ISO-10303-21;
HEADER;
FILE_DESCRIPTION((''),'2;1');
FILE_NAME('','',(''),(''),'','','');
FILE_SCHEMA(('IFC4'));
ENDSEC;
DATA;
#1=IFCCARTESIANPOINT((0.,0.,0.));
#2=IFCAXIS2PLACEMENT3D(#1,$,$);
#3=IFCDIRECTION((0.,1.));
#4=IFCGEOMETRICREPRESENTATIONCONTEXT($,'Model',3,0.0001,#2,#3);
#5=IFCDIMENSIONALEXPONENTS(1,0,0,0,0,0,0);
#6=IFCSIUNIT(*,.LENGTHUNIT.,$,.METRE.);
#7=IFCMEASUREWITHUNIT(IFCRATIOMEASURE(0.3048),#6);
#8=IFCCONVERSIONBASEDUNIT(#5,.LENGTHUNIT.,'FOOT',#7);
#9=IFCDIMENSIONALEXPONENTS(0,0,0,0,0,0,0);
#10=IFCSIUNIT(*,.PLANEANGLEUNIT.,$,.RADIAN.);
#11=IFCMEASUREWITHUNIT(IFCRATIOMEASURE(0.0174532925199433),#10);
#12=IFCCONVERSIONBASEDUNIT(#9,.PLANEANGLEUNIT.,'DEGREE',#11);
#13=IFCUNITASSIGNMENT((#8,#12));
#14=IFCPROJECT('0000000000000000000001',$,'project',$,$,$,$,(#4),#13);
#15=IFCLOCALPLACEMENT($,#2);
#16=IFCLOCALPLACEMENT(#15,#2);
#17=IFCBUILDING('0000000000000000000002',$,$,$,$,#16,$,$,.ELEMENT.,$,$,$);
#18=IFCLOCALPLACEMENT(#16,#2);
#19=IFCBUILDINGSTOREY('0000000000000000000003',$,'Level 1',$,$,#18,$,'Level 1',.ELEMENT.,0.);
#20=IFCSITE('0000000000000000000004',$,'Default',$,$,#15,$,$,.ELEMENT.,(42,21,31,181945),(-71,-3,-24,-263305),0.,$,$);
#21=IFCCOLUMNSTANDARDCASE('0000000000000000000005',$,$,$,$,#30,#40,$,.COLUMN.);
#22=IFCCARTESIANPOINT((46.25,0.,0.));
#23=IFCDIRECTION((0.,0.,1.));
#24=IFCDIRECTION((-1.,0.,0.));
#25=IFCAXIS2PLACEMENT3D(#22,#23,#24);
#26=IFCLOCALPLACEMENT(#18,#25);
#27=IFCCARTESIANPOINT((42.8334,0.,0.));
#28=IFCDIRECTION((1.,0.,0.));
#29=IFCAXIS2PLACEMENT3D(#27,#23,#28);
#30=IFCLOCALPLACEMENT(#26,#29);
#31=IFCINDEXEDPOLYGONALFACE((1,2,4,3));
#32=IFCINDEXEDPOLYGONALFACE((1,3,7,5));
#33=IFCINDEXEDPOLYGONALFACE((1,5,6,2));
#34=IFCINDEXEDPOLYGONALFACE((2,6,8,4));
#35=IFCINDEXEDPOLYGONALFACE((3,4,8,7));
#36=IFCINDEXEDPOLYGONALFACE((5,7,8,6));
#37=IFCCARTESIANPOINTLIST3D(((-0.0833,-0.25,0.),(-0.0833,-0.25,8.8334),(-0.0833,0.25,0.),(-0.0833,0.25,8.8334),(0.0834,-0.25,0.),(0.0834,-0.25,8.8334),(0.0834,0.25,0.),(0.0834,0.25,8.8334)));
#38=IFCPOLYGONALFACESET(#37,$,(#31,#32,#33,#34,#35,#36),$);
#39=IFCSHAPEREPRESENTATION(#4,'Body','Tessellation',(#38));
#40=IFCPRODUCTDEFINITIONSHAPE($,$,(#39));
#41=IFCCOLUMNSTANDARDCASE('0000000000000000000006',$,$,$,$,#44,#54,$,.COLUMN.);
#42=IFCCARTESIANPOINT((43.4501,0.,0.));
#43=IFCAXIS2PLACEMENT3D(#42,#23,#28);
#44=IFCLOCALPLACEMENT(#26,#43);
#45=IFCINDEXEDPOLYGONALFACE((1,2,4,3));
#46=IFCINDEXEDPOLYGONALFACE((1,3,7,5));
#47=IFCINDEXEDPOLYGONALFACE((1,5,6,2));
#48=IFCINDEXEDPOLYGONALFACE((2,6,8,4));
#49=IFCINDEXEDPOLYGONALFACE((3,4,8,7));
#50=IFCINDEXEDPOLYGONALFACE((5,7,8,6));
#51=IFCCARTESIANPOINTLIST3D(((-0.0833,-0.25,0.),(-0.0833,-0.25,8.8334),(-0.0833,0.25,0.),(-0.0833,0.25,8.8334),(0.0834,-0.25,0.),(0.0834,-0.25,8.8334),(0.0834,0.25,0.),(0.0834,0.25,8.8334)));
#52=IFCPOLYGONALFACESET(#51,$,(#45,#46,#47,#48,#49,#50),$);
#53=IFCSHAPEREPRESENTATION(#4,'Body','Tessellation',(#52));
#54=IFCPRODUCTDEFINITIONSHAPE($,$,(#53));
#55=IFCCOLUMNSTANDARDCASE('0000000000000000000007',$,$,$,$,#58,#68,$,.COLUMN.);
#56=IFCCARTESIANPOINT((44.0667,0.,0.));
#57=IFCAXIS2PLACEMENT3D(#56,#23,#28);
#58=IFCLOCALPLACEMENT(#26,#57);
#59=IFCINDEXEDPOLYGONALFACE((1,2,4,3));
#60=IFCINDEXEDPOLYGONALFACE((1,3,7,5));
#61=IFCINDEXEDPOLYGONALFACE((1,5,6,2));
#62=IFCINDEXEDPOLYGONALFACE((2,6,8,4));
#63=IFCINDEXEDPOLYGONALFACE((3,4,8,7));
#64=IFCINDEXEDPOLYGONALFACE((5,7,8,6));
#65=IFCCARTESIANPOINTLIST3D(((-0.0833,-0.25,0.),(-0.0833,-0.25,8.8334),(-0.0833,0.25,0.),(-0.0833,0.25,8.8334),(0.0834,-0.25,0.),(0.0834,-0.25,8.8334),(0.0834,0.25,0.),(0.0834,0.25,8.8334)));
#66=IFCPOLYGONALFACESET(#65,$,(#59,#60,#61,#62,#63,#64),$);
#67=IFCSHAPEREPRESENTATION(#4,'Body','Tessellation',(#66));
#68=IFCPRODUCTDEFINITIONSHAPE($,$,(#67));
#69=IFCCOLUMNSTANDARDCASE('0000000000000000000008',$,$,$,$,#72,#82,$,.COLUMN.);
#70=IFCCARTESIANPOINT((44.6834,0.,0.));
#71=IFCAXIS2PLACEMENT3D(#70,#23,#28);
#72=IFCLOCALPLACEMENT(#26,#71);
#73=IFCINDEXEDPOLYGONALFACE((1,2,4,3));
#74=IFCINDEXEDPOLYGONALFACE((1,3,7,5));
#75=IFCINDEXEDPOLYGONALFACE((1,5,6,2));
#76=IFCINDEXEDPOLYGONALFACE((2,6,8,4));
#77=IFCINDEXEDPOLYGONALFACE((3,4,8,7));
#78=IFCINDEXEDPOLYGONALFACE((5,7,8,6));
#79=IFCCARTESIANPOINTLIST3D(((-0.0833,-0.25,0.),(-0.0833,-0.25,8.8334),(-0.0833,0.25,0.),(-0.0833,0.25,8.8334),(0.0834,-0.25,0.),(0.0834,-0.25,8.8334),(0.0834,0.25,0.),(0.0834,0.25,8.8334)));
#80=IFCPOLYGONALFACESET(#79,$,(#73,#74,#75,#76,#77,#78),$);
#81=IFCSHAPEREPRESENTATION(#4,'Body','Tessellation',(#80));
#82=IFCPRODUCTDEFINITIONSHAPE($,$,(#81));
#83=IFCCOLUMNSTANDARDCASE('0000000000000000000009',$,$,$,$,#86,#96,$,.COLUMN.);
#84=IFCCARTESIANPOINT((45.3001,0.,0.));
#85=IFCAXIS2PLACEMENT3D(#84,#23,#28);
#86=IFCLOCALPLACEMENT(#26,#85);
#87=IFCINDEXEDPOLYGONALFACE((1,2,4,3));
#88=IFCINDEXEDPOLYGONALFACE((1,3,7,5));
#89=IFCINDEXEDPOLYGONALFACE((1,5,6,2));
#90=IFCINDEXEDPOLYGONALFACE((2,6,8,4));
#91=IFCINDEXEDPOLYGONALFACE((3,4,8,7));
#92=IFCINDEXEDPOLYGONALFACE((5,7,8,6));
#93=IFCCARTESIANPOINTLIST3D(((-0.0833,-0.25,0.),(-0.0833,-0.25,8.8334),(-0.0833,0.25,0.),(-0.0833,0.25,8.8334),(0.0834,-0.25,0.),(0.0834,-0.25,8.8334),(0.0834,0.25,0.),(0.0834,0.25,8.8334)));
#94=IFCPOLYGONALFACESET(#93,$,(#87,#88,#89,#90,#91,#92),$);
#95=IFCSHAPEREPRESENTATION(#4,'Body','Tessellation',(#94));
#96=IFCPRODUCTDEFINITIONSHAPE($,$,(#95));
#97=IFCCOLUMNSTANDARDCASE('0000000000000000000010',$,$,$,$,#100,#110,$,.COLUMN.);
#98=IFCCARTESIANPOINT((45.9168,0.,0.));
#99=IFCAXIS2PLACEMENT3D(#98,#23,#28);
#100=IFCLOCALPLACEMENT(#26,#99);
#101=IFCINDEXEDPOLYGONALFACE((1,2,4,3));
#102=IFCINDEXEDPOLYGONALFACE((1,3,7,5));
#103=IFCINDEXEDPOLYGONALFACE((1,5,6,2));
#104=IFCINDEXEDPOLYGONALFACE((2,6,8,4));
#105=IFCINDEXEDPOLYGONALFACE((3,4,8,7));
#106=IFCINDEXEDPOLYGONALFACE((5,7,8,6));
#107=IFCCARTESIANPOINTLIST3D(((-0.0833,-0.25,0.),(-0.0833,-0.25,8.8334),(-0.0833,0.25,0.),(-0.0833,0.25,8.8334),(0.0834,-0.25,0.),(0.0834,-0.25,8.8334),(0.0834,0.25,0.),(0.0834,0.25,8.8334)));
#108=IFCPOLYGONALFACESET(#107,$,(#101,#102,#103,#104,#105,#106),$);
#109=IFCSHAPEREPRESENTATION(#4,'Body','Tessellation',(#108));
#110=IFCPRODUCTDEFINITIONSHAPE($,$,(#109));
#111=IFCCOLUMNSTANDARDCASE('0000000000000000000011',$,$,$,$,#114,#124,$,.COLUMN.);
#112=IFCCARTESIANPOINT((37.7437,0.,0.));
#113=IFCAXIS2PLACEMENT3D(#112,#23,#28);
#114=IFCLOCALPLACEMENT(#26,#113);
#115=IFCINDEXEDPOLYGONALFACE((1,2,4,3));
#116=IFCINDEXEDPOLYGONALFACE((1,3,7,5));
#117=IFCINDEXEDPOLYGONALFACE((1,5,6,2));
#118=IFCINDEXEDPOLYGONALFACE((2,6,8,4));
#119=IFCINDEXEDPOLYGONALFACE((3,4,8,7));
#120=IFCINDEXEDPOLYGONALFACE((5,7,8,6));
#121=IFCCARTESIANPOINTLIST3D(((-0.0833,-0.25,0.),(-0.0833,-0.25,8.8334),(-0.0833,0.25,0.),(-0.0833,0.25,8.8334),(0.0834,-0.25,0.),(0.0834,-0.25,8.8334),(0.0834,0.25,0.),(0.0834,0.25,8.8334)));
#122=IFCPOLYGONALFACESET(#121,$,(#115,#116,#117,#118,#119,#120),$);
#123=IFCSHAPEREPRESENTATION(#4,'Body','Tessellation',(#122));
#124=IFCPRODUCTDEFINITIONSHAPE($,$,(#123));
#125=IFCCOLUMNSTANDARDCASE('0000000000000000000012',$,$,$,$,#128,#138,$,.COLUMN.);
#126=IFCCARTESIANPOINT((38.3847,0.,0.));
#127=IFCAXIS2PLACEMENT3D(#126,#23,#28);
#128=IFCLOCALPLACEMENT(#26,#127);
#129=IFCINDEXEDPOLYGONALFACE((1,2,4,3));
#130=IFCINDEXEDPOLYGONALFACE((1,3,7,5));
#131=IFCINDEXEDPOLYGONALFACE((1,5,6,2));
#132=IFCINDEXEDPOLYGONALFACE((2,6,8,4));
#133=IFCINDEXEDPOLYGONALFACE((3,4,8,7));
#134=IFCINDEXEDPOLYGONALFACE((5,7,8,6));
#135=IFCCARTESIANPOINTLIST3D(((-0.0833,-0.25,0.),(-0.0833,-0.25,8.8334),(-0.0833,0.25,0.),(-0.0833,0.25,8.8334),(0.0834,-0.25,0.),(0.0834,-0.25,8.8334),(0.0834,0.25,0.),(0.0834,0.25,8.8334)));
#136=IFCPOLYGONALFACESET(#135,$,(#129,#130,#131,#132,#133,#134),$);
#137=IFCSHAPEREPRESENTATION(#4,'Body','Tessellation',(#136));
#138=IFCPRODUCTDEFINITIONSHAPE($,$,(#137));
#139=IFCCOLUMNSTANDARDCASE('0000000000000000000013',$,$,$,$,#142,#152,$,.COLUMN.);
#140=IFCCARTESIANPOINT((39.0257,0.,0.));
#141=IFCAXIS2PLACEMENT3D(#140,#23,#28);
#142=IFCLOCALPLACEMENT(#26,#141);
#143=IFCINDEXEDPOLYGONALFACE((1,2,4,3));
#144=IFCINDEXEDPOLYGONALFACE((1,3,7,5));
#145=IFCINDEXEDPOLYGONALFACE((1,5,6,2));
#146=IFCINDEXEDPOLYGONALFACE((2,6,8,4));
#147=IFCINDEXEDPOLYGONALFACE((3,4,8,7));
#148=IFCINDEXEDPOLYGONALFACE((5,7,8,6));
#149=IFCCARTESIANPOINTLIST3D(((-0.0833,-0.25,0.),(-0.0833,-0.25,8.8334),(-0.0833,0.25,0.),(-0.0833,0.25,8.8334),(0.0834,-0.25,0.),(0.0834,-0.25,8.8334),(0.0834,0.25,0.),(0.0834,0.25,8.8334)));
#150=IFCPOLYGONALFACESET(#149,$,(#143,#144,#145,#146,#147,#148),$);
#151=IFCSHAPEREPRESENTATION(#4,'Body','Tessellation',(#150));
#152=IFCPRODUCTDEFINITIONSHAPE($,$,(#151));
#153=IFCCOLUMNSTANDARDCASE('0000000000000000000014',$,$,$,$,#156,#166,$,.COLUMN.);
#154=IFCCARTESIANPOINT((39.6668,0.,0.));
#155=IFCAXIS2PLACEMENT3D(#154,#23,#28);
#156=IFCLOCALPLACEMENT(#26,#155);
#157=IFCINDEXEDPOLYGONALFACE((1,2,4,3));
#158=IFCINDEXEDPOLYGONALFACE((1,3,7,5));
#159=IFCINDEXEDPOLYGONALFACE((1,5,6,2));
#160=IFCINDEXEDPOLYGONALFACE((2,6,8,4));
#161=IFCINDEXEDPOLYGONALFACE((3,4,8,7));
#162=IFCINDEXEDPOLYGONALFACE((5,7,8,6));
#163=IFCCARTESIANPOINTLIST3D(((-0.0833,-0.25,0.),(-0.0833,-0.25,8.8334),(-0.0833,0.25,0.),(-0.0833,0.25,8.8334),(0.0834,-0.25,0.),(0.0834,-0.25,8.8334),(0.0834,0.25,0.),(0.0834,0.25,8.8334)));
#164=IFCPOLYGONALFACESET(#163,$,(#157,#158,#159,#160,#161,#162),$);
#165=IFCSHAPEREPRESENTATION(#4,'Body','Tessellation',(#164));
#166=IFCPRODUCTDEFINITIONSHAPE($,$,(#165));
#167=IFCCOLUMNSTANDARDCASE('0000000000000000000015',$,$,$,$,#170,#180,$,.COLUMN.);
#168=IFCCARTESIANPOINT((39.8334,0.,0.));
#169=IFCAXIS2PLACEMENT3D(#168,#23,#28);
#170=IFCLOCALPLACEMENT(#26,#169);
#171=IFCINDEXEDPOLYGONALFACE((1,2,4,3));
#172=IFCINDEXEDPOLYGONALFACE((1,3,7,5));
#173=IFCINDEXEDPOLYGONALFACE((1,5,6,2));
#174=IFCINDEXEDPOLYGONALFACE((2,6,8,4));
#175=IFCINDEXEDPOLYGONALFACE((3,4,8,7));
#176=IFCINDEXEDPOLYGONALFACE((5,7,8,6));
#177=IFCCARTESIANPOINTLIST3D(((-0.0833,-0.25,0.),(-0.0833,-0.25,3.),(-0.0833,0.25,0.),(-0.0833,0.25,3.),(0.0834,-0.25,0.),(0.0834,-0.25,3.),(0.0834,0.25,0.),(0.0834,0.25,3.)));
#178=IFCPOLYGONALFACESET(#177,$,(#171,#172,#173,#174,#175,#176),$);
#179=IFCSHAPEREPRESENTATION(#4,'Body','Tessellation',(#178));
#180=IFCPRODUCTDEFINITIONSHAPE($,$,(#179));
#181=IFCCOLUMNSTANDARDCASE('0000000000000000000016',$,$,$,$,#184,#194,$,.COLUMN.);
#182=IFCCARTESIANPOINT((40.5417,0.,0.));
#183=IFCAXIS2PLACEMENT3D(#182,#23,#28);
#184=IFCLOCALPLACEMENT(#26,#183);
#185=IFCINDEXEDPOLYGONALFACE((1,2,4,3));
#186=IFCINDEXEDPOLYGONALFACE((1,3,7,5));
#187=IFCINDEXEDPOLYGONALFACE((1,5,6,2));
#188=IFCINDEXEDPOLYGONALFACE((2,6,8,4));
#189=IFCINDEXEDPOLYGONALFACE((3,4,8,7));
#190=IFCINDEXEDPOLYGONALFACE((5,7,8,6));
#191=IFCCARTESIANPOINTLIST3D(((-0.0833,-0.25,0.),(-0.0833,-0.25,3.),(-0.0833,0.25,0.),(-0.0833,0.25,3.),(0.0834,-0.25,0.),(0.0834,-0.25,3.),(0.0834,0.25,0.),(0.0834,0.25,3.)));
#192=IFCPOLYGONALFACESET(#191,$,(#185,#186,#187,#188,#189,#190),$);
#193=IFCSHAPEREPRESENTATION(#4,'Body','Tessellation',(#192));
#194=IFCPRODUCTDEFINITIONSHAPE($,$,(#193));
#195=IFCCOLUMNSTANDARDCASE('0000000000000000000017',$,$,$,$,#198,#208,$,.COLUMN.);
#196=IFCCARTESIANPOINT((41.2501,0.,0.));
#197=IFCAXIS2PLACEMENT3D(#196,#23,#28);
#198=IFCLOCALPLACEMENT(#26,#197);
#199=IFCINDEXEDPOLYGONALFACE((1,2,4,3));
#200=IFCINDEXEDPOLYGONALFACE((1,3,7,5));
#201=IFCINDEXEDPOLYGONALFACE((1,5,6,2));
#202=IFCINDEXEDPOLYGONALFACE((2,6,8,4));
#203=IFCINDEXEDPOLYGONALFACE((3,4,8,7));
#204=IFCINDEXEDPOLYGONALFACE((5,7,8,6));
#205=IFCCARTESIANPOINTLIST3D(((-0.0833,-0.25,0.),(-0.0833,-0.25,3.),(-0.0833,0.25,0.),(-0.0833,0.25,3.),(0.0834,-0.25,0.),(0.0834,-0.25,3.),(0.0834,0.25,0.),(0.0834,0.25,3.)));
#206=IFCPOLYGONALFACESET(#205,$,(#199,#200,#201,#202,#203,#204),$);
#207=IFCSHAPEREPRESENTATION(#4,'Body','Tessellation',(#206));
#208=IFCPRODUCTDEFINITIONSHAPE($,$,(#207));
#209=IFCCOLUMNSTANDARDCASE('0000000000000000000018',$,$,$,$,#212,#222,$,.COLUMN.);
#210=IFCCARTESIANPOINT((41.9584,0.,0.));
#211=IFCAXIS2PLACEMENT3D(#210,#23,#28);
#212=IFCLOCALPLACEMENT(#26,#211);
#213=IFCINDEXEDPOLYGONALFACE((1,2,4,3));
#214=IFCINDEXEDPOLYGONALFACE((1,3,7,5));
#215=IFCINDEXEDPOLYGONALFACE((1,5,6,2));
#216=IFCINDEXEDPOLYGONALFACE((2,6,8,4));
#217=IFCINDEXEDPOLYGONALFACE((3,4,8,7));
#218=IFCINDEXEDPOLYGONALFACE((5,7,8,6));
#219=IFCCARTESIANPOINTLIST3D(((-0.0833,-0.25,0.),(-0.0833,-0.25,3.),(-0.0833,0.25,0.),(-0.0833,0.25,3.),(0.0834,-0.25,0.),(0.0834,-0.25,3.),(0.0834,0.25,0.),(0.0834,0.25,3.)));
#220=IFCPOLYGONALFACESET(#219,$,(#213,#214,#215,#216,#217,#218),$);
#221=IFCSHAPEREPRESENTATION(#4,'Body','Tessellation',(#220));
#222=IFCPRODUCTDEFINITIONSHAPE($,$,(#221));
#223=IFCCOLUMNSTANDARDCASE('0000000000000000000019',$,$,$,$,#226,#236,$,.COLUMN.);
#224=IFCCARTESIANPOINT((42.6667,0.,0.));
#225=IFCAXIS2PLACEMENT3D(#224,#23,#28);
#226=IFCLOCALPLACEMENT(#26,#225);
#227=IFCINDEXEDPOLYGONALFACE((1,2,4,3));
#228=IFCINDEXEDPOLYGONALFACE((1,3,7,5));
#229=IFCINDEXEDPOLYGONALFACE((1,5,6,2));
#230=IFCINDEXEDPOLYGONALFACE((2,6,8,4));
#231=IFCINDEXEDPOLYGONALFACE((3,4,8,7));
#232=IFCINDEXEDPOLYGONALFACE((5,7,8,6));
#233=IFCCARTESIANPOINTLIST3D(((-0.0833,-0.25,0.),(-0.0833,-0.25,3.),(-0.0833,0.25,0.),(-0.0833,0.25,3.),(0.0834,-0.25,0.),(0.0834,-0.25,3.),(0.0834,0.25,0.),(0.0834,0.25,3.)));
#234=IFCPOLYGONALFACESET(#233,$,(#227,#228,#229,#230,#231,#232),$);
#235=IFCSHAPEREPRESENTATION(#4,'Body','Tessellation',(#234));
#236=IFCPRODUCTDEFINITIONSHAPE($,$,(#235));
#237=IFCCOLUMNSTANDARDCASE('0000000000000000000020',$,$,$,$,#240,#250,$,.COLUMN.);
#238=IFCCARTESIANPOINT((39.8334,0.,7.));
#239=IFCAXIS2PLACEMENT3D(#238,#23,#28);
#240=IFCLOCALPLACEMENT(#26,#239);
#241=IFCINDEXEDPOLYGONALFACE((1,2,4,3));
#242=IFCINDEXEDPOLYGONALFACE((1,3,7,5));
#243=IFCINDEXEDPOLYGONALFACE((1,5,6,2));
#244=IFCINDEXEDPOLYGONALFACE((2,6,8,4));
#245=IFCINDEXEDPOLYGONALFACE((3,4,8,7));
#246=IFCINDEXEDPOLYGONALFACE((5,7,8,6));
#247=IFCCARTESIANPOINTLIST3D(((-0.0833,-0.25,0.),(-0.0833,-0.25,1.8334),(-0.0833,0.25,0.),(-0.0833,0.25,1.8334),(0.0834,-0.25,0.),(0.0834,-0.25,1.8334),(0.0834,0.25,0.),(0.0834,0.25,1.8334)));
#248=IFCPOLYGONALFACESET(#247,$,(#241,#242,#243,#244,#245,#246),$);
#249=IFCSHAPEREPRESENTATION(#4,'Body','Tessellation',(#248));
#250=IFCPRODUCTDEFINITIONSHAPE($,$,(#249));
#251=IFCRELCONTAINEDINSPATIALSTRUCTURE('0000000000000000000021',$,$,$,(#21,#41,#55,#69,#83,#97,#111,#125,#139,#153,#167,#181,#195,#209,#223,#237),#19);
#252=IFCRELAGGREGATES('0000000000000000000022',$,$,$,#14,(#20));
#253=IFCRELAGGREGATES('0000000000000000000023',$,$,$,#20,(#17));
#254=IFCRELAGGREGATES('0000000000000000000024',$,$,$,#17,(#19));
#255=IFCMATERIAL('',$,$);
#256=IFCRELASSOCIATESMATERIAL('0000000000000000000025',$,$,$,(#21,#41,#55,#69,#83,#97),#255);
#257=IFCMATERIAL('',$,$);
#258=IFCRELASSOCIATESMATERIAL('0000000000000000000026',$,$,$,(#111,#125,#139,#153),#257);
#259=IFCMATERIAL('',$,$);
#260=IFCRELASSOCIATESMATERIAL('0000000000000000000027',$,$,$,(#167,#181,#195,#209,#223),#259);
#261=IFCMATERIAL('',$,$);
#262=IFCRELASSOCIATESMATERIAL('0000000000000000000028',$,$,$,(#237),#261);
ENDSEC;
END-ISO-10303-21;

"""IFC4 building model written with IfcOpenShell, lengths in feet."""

from ifc_helpers import new_model, entity, si_unit, converted_unit, direction, frame, origin, place, context, project, spatial, rectangle, extrude, material, element, save


model = new_model("IFC4")

# Units and contexts
model_context = context("Model", 3, precision=0.0001, world=origin(), true_north=direction((0.0, 1.0)))
ifc_project = project(units=[converted_unit("LENGTHUNIT", "FOOT", entity("IfcRatioMeasure", 0.3048), si_unit("LENGTHUNIT", "METRE"), dimensions=[1, 0, 0, 0, 0, 0, 0]), converted_unit("PLANEANGLEUNIT", "DEGREE", entity("IfcRatioMeasure", 0.0174532925199433), si_unit("PLANEANGLEUNIT", "RADIAN"), dimensions=[0, 0, 0, 0, 0, 0, 0])], contexts=[model_context])

# Site, building, storey
site_placement = place(None, origin())
site = spatial("IfcSite", under=ifc_project, at=site_placement, Name="Default", CompositionType="ELEMENT", RefLatitude=(42, 21, 31, 181945), RefLongitude=(-71, -3, -24, -263305), RefElevation=0.0)
building_placement = place(site_placement, origin())
building = spatial("IfcBuilding", under=site, at=building_placement, CompositionType="ELEMENT")
storey_placement = place(building_placement, origin())
storey = spatial("IfcBuildingStorey", under=building, at=storey_placement, Name="Level 1", LongName="Level 1", CompositionType="ELEMENT", Elevation=0.0)

# Columns
ifc_material_1 = material(Name="")
placement_1 = place(storey_placement, frame((46.25, 0.0, 0.0), z_axis=(0.0, 0.0, 1.0), x_axis=(-1.0, 0.0, 0.0)))
for number, where, z_axis, x_axis in (
    (1, (42.8334, 0.0, 0.0), (0.0, 0.0, 1.0), (1.0, 0.0, 0.0)),
    (2, (43.4501, 0.0, 0.0), (0.0, 0.0, 1.0), (1.0, 0.0, 0.0)),
    (3, (44.0667, 0.0, 0.0), (0.0, 0.0, 1.0), (1.0, 0.0, 0.0)),
    (4, (44.6834, 0.0, 0.0), (0.0, 0.0, 1.0), (1.0, 0.0, 0.0)),
    (5, (45.3001, 0.0, 0.0), (0.0, 0.0, 1.0), (1.0, 0.0, 0.0)),
    (6, (45.9168, 0.0, 0.0), (0.0, 0.0, 1.0), (1.0, 0.0, 0.0)),
):
    element("IfcColumnStandardCase", number, at=place(placement_1, frame(where, z_axis=z_axis, x_axis=x_axis)), inside=storey, material=ifc_material_1, PredefinedType="COLUMN", context=model_context, shape_type="SweptSolid", body=[
        extrude(rectangle(XDim=0.1667, YDim=0.5), origin(), (0.0, 0.0, 1.0), 8.8334),
    ])
ifc_material_2 = material(Name="")
for number, where, z_axis, x_axis in (
    (7, (37.7437, 0.0, 0.0), (0.0, 0.0, 1.0), (1.0, 0.0, 0.0)),
    (8, (38.3847, 0.0, 0.0), (0.0, 0.0, 1.0), (1.0, 0.0, 0.0)),
    (9, (39.0257, 0.0, 0.0), (0.0, 0.0, 1.0), (1.0, 0.0, 0.0)),
    (10, (39.6668, 0.0, 0.0), (0.0, 0.0, 1.0), (1.0, 0.0, 0.0)),
):
    element("IfcColumnStandardCase", number, at=place(placement_1, frame(where, z_axis=z_axis, x_axis=x_axis)), inside=storey, material=ifc_material_2, PredefinedType="COLUMN", context=model_context, shape_type="SweptSolid", body=[
        extrude(rectangle(XDim=0.1667, YDim=0.5), origin(), (0.0, 0.0, 1.0), 8.8334),
    ])
ifc_material_3 = material(Name="")
for number, where, z_axis, x_axis in (
    (11, (39.8334, 0.0, 0.0), (0.0, 0.0, 1.0), (1.0, 0.0, 0.0)),
    (12, (40.5417, 0.0, 0.0), (0.0, 0.0, 1.0), (1.0, 0.0, 0.0)),
    (13, (41.2501, 0.0, 0.0), (0.0, 0.0, 1.0), (1.0, 0.0, 0.0)),
    (14, (41.9584, 0.0, 0.0), (0.0, 0.0, 1.0), (1.0, 0.0, 0.0)),
    (15, (42.6667, 0.0, 0.0), (0.0, 0.0, 1.0), (1.0, 0.0, 0.0)),
):
    element("IfcColumnStandardCase", number, at=place(placement_1, frame(where, z_axis=z_axis, x_axis=x_axis)), inside=storey, material=ifc_material_3, PredefinedType="COLUMN", context=model_context, shape_type="SweptSolid", body=[
        extrude(rectangle(XDim=0.1667, YDim=0.5), origin(), (0.0, 0.0, 1.0), 3.0),
    ])
ifc_material_4 = material(Name="")
for number, where, z_axis, x_axis in (
    (16, (39.8334, 0.0, 7.0), (0.0, 0.0, 1.0), (1.0, 0.0, 0.0)),
):
    element("IfcColumnStandardCase", number, at=place(placement_1, frame(where, z_axis=z_axis, x_axis=x_axis)), inside=storey, material=ifc_material_4, PredefinedType="COLUMN", context=model_context, shape_type="SweptSolid", body=[
        extrude(rectangle(XDim=0.1667, YDim=0.5), origin(), (0.0, 0.0, 1.0), 1.8334),
    ])

save(model, "model.ifc")
